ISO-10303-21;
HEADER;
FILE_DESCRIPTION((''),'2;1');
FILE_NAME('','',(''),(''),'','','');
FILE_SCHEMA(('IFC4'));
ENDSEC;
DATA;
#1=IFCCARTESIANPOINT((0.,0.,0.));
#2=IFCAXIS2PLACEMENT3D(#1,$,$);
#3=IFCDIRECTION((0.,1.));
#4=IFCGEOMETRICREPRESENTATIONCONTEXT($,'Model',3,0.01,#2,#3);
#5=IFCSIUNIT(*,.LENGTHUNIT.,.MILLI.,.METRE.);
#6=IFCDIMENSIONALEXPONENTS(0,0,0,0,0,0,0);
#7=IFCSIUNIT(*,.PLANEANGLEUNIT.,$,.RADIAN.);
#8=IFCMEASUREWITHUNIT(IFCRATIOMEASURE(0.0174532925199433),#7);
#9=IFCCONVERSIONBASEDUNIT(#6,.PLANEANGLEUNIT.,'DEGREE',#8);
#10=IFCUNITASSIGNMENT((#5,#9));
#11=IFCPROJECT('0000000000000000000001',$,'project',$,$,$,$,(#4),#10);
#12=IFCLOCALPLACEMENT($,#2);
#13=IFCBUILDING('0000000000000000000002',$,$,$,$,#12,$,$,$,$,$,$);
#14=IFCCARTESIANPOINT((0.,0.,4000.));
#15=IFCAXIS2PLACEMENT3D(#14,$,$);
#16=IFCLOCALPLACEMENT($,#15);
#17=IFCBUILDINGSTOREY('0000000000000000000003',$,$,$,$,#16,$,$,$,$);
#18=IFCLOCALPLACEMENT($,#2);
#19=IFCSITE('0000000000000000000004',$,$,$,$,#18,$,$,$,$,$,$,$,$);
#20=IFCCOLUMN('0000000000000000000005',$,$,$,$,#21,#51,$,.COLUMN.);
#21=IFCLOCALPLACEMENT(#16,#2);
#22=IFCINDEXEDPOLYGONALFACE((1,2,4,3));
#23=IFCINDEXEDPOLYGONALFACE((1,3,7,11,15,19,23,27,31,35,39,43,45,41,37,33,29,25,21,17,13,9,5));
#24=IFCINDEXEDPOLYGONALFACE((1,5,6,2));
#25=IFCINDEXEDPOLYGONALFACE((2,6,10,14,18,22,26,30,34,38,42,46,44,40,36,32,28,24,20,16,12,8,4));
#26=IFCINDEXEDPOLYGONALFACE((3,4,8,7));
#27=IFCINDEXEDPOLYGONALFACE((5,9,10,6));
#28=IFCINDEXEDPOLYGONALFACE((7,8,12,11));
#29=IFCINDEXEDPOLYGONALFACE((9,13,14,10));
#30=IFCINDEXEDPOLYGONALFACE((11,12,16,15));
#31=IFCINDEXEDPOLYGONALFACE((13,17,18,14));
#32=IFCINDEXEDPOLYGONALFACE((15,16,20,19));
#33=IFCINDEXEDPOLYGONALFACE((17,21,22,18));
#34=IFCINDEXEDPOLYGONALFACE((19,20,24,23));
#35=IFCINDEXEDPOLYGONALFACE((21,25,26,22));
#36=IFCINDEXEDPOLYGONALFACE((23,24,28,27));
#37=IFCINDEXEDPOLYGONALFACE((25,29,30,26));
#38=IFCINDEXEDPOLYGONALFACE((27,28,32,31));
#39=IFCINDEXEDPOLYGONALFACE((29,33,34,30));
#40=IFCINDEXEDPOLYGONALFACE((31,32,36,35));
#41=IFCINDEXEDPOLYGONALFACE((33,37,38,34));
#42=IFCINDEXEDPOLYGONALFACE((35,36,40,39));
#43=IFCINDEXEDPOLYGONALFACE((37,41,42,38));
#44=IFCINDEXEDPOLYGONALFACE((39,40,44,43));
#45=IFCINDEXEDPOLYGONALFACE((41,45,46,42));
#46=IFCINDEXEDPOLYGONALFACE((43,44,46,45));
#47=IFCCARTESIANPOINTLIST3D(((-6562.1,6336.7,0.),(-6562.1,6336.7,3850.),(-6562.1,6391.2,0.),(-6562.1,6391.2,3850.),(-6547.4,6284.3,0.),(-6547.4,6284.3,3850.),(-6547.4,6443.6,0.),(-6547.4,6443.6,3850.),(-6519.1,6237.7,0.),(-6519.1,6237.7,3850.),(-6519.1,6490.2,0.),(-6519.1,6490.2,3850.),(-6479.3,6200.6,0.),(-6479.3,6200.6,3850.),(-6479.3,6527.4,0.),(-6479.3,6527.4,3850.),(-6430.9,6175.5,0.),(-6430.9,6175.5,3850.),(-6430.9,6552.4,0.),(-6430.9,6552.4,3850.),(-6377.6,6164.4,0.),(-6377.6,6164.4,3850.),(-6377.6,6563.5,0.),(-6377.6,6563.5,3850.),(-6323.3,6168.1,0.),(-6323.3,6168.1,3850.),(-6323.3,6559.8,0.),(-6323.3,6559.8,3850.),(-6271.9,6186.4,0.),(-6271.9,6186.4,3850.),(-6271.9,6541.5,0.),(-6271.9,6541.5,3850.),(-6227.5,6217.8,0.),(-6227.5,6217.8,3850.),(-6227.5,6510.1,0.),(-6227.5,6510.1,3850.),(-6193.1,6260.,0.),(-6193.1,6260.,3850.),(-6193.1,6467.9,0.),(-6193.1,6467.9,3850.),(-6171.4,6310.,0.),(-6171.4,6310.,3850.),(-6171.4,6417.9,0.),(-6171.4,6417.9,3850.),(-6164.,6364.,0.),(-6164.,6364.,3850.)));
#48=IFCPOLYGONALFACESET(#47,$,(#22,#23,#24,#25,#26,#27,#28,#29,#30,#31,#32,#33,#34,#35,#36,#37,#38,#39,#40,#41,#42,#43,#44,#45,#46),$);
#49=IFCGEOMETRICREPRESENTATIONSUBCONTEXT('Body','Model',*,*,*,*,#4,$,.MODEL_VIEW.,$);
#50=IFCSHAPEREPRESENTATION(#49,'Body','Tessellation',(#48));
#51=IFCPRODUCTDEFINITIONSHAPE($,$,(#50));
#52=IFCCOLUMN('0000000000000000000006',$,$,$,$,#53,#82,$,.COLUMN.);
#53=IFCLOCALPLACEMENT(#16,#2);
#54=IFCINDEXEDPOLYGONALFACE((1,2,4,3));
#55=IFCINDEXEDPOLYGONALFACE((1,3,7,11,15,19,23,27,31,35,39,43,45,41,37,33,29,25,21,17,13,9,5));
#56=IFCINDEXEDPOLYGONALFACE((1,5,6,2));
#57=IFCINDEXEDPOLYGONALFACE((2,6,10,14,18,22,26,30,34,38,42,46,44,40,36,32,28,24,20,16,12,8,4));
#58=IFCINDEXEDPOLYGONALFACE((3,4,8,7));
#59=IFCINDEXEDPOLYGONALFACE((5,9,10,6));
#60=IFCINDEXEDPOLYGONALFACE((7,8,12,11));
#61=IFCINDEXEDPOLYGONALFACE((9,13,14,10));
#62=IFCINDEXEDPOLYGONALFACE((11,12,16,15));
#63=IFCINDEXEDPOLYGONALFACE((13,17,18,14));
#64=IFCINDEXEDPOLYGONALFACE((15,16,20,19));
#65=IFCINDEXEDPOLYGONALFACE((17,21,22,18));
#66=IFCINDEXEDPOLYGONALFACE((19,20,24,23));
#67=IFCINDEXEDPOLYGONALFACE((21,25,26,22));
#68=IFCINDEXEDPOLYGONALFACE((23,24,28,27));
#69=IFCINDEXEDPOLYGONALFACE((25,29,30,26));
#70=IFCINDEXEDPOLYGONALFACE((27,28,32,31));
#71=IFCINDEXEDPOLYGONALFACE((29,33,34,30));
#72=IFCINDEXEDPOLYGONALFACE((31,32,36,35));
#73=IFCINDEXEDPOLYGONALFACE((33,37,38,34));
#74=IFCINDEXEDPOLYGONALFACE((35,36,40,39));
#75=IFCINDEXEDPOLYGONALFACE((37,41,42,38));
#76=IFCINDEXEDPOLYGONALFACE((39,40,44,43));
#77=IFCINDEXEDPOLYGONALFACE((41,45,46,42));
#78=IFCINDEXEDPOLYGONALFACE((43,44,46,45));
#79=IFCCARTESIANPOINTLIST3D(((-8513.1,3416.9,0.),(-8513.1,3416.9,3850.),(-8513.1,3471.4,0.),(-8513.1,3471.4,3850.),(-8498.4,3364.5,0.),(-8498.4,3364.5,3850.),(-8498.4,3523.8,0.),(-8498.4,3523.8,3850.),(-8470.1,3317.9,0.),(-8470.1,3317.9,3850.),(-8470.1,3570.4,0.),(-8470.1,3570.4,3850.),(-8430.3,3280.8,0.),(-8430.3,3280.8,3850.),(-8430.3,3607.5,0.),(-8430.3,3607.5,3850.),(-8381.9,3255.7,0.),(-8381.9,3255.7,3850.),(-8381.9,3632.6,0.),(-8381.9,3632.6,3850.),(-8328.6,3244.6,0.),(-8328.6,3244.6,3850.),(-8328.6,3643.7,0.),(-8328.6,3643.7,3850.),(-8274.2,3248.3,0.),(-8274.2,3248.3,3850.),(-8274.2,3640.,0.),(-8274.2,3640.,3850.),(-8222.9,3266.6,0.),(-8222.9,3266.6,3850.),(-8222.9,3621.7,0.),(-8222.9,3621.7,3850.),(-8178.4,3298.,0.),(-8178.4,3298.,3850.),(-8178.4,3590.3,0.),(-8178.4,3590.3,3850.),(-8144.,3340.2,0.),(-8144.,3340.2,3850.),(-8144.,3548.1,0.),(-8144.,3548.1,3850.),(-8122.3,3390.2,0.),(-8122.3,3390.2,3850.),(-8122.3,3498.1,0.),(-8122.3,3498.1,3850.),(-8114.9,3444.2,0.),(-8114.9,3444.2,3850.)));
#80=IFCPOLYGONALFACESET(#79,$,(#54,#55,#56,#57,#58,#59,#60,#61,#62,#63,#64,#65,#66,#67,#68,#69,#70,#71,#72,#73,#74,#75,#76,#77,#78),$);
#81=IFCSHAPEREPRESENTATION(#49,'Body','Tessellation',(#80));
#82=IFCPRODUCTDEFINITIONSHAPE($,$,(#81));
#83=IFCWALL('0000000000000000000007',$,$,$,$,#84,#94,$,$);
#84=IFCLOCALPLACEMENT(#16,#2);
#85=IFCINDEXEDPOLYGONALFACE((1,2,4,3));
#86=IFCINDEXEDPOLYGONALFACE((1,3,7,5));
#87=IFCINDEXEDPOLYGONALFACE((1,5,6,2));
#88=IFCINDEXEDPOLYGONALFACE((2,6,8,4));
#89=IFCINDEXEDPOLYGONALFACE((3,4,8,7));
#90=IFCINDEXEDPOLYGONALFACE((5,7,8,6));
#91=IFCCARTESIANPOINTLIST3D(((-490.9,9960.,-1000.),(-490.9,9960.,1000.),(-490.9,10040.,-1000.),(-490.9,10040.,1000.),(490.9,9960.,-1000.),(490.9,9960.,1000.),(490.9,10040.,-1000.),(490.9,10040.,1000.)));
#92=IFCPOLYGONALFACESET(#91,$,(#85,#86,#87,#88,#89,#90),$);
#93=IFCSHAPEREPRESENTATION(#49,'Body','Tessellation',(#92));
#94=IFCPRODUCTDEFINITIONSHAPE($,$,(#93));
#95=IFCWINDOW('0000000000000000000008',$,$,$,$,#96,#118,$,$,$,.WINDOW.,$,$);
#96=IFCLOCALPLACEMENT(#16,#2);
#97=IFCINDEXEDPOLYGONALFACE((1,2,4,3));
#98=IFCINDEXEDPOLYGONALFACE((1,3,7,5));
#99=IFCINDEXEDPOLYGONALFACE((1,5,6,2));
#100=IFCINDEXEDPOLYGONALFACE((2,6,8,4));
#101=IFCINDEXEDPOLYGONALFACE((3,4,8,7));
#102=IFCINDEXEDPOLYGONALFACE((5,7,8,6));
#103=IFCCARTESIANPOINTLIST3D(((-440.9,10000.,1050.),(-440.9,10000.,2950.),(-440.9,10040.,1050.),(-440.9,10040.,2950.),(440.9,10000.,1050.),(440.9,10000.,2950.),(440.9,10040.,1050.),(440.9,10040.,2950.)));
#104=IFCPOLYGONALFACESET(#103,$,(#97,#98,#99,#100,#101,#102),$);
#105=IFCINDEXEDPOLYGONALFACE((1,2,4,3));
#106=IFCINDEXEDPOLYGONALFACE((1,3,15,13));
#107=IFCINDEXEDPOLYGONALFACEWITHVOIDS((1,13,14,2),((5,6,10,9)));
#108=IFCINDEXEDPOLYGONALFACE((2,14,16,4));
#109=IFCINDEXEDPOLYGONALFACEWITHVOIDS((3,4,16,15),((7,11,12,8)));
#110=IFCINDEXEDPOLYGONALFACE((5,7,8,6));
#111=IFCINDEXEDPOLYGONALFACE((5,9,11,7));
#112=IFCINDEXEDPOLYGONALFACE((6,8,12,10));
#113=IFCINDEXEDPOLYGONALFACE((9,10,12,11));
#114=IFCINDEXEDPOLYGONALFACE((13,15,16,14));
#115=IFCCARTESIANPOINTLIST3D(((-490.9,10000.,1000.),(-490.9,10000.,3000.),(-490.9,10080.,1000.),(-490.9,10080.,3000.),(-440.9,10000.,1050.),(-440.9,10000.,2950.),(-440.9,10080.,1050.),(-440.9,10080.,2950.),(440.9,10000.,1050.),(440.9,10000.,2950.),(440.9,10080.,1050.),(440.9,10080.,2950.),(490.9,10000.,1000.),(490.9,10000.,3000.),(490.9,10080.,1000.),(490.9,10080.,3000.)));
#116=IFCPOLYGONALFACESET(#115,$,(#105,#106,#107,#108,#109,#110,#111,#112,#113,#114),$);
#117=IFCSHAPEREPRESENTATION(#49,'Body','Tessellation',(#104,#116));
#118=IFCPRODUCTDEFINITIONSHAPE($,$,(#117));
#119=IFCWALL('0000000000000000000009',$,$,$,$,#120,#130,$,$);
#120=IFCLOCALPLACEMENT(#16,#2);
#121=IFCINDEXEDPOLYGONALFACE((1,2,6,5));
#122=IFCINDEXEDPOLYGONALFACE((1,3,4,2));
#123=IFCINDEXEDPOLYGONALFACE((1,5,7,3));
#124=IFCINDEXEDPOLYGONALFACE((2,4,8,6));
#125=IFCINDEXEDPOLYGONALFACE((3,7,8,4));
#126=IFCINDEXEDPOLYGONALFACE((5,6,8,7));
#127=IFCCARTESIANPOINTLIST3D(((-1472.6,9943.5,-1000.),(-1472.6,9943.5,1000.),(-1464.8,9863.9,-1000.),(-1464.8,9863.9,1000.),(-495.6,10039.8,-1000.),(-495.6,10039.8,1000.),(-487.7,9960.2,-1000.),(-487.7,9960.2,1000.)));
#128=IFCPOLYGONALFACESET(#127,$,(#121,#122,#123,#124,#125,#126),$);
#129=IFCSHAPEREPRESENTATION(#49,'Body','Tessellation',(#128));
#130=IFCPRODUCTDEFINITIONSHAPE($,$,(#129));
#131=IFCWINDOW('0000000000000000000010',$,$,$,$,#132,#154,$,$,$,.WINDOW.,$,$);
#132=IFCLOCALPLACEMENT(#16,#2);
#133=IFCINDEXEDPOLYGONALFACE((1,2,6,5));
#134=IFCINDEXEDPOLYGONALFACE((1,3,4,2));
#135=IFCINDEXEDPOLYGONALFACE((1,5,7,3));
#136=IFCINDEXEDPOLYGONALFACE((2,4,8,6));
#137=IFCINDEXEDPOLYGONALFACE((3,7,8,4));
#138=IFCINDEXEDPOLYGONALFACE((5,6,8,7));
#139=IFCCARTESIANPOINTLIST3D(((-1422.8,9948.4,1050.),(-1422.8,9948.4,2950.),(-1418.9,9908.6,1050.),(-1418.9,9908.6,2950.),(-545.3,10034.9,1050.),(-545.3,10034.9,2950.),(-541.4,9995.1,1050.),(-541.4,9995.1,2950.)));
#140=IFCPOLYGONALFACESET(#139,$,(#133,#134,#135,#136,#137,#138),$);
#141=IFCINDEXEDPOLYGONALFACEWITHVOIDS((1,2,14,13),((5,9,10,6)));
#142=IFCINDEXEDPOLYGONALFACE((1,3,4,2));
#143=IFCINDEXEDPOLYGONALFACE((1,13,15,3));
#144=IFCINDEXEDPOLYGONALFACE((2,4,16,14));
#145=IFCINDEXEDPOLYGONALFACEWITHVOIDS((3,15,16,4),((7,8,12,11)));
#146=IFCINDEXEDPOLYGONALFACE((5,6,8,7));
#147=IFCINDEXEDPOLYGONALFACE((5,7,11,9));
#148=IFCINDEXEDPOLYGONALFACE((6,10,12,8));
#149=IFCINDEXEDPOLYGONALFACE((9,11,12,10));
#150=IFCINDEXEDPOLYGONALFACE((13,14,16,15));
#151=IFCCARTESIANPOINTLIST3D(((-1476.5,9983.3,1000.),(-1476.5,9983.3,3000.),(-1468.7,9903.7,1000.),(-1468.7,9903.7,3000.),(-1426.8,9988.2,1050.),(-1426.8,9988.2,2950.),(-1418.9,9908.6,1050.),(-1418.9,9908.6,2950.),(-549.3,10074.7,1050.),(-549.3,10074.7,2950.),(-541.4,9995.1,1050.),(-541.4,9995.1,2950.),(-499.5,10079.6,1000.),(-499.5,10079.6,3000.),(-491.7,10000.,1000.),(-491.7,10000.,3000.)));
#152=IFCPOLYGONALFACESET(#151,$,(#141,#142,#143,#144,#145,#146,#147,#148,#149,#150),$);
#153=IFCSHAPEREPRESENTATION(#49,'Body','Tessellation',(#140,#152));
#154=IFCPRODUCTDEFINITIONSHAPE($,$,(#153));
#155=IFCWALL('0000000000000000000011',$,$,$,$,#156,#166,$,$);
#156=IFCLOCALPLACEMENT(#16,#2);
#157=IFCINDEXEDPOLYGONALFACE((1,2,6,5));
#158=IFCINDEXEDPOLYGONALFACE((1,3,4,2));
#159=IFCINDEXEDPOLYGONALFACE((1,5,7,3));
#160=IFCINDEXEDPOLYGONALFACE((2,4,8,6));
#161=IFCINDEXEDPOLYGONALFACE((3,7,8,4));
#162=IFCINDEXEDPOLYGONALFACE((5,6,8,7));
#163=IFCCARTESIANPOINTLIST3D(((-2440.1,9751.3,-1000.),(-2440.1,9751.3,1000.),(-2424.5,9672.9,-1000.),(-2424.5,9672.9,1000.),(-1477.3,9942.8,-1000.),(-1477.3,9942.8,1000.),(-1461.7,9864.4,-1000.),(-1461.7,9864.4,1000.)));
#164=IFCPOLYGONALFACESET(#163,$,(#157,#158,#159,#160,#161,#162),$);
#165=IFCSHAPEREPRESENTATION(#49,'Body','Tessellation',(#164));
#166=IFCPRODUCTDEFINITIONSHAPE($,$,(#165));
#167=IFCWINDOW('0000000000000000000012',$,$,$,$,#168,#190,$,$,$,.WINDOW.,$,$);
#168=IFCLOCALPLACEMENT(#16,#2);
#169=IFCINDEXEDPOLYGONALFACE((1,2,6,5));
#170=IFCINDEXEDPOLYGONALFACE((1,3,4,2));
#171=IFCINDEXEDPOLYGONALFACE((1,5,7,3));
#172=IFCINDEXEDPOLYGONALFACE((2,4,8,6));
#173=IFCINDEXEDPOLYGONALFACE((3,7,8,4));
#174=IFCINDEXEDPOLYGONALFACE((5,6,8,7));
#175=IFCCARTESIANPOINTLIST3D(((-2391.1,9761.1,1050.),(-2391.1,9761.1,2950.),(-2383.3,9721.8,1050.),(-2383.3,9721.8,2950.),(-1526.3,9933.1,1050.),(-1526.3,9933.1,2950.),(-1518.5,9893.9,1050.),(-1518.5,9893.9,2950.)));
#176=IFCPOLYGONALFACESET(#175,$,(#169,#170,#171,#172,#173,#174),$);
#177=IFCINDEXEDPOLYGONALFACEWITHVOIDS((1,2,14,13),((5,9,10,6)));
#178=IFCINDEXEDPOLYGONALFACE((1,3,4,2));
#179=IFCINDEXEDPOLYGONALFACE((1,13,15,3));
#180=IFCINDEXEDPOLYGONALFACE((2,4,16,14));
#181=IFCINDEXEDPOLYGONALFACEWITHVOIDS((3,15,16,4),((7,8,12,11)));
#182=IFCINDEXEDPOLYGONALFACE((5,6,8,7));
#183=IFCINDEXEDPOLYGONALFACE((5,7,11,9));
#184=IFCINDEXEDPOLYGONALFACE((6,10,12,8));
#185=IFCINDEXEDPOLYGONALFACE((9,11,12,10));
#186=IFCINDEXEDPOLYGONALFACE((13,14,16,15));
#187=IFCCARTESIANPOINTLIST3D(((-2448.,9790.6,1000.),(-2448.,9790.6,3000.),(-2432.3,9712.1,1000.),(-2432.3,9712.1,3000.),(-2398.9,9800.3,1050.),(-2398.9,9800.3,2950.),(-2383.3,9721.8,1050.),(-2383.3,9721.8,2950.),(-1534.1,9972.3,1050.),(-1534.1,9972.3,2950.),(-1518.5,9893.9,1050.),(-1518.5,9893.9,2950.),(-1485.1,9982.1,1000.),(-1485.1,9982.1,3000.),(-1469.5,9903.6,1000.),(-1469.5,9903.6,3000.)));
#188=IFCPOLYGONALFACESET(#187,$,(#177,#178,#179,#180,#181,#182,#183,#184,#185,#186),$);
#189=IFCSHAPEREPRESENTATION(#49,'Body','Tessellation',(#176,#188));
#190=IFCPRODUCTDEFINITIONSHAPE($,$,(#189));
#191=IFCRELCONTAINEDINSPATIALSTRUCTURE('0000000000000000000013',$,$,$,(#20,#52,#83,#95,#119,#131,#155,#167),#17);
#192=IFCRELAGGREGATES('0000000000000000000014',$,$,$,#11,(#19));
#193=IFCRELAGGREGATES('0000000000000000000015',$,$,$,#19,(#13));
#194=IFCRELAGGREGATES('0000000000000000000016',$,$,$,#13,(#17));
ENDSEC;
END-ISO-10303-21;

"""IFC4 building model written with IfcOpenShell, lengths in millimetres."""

from ifc_helpers import new_model, entity, si_unit, converted_unit, direction, frame, origin, origin_2d, place, context, subcontext, project, spatial, rectangle, circle, extrude, element, save


model = new_model("IFC4")

# Units and contexts
model_context = context("Model", 3, precision=0.01, world=origin(), true_north=direction((0.0, 1.0)))
body_context = subcontext(model_context, "Body", "Model", "MODEL_VIEW")
ifc_project = project(units=[si_unit("LENGTHUNIT", "METRE", prefix="MILLI"), converted_unit("PLANEANGLEUNIT", "DEGREE", entity("IfcRatioMeasure", 0.0174532925199433), si_unit("PLANEANGLEUNIT", "RADIAN"), dimensions=[0, 0, 0, 0, 0, 0, 0])], contexts=[model_context])

# Site, building, storey
site_placement = place(None, origin())
site = spatial("IfcSite", under=ifc_project, at=site_placement)
building_placement = place(None, origin())
building = spatial("IfcBuilding", under=site, at=building_placement)
storey_placement = place(None, frame((0.0, 0.0, 4000.0)))
storey = spatial("IfcBuildingStorey", under=building, at=storey_placement)

# Columns
for number, where in (
    (1, (-6364.0, 6364.0, 0.0)),
    (2, (-8314.9, 3444.2, 0.0)),
):
    element("IfcColumn", number, at=place(storey_placement, frame(where)), inside=storey, PredefinedType="COLUMN", context=body_context, shape_type="SweptSolid", body=[
        extrude(circle(Radius=200.0, at=origin_2d()), origin(), (0.0, 0.0, 1.0), 3850.0),
    ])

# Wall
wall_1_placement = place(storey_placement, frame((0.0, 10000.0, -1000.0), z_axis=(0.0, 0.0, 1.0), x_axis=(-10000.0, -0.000437, 0.0)))
element("IfcWall", 3, at=wall_1_placement, inside=storey, context=body_context, shape_type="SweptSolid", body=[
    extrude(rectangle(XDim=981.7, YDim=80.0, at=origin_2d()), origin(), (0.0, 0.0, 1.0), 2000.0),
])

# Window
cartesian_point_1 = entity("IfcCartesianPoint", [-440.9, -950.0])
shared_polyline = entity("IfcPolyline", [cartesian_point_1, entity("IfcCartesianPoint", [-440.9, 950.0]), entity("IfcCartesianPoint", [-440.9, 950.0]), entity("IfcCartesianPoint", [440.9, 950.0]), entity("IfcCartesianPoint", [440.9, 950.0]), entity("IfcCartesianPoint", [440.9, -950.0]), entity("IfcCartesianPoint", [440.9, -950.0]), entity("IfcCartesianPoint", [-440.9, -950.0]), cartesian_point_1])
window_1_placement = place(storey_placement, frame((0.0, 10000.0, 2000.0), z_axis=(0.0, 0.0, 1.0), x_axis=(-10000.0, -0.000437, 0.0)))
cartesian_point_2 = entity("IfcCartesianPoint", [-490.9, -1000.0])
element("IfcWindow", 4, at=window_1_placement, inside=storey, PredefinedType="WINDOW", context=body_context, shape_type="SweptSolid", body=[
    entity("IfcExtrudedAreaSolid", entity("IfcArbitraryClosedProfileDef", "AREA", None, shared_polyline), entity("IfcAxis2Placement3D", entity("IfcCartesianPoint", [0.0, 0.0, 0.0]), entity("IfcDirection", [0.0, -1.0, 0.0]), entity("IfcDirection", [1.0, 0.0, 0.0])), entity("IfcDirection", [0.0, 0.0, 1.0]), 40.0),
    entity("IfcExtrudedAreaSolid", entity("IfcArbitraryProfileDefWithVoids", "AREA", None, entity("IfcPolyline", [cartesian_point_2, entity("IfcCartesianPoint", [-490.9, 1000.0]), entity("IfcCartesianPoint", [-490.9, 1000.0]), entity("IfcCartesianPoint", [490.9, 1000.0]), entity("IfcCartesianPoint", [490.9, 1000.0]), entity("IfcCartesianPoint", [490.9, -1000.0]), entity("IfcCartesianPoint", [490.9, -1000.0]), entity("IfcCartesianPoint", [-490.9, -1000.0]), cartesian_point_2]), [shared_polyline]), entity("IfcAxis2Placement3D", entity("IfcCartesianPoint", [0.0, 0.0, 0.0]), entity("IfcDirection", [0.0, -1.0, 0.0]), entity("IfcDirection", [1.0, 0.0, 0.0])), entity("IfcDirection", [0.0, 0.0, 1.0]), 80.0),
])

# Wall
wall_2_placement = place(storey_placement, frame((-980.2, 9951.8, -1000.0), z_axis=(0.0, 0.0, 1.0), x_axis=(-9951.847302, -980.17105, 0.0)))
element("IfcWall", 5, at=wall_2_placement, inside=storey, context=body_context, shape_type="SweptSolid", body=[
    extrude(rectangle(XDim=981.7, YDim=80.0, at=origin_2d()), origin(), (0.0, 0.0, 1.0), 2000.0),
])

# Window
window_2_placement = place(storey_placement, frame((-980.2, 9951.8, 2000.0), z_axis=(0.0, 0.0, 1.0), x_axis=(-9951.847302, -980.17105, 0.0)))
cartesian_point_3 = entity("IfcCartesianPoint", [-490.9, -1000.0])
element("IfcWindow", 6, at=window_2_placement, inside=storey, PredefinedType="WINDOW", context=body_context, shape_type="SweptSolid", body=[
    entity("IfcExtrudedAreaSolid", entity("IfcArbitraryClosedProfileDef", "AREA", None, shared_polyline), entity("IfcAxis2Placement3D", entity("IfcCartesianPoint", [0.0, 0.0, 0.0]), entity("IfcDirection", [0.0, -1.0, 0.0]), entity("IfcDirection", [1.0, 0.0, 0.0])), entity("IfcDirection", [0.0, 0.0, 1.0]), 40.0),
    entity("IfcExtrudedAreaSolid", entity("IfcArbitraryProfileDefWithVoids", "AREA", None, entity("IfcPolyline", [cartesian_point_3, entity("IfcCartesianPoint", [-490.9, 1000.0]), entity("IfcCartesianPoint", [-490.9, 1000.0]), entity("IfcCartesianPoint", [490.9, 1000.0]), entity("IfcCartesianPoint", [490.9, 1000.0]), entity("IfcCartesianPoint", [490.9, -1000.0]), entity("IfcCartesianPoint", [490.9, -1000.0]), entity("IfcCartesianPoint", [-490.9, -1000.0]), cartesian_point_3]), [shared_polyline]), entity("IfcAxis2Placement3D", entity("IfcCartesianPoint", [0.0, 0.0, 0.0]), entity("IfcDirection", [0.0, -1.0, 0.0]), entity("IfcDirection", [1.0, 0.0, 0.0])), entity("IfcDirection", [0.0, 0.0, 1.0]), 80.0),
])

# Wall
wall_3_placement = place(storey_placement, frame((-1950.9, 9807.9, -1000.0), z_axis=(0.0, 0.0, 1.0), x_axis=(-9807.852795, -1950.903264, 0.0)))
element("IfcWall", 7, at=wall_3_placement, inside=storey, context=body_context, shape_type="SweptSolid", body=[
    extrude(rectangle(XDim=981.7, YDim=80.0, at=origin_2d()), origin(), (0.0, 0.0, 1.0), 2000.0),
])

# Window
window_3_placement = place(storey_placement, frame((-1950.9, 9807.9, 2000.0), z_axis=(0.0, 0.0, 1.0), x_axis=(-9807.852795, -1950.903264, 0.0)))
cartesian_point_4 = entity("IfcCartesianPoint", [-490.9, -1000.0])
element("IfcWindow", 8, at=window_3_placement, inside=storey, PredefinedType="WINDOW", context=body_context, shape_type="SweptSolid", body=[
    entity("IfcExtrudedAreaSolid", entity("IfcArbitraryClosedProfileDef", "AREA", None, shared_polyline), entity("IfcAxis2Placement3D", entity("IfcCartesianPoint", [0.0, 0.0, 0.0]), entity("IfcDirection", [0.0, -1.0, 0.0]), entity("IfcDirection", [1.0, 0.0, 0.0])), entity("IfcDirection", [0.0, 0.0, 1.0]), 40.0),
    entity("IfcExtrudedAreaSolid", entity("IfcArbitraryProfileDefWithVoids", "AREA", None, entity("IfcPolyline", [cartesian_point_4, entity("IfcCartesianPoint", [-490.9, 1000.0]), entity("IfcCartesianPoint", [-490.9, 1000.0]), entity("IfcCartesianPoint", [490.9, 1000.0]), entity("IfcCartesianPoint", [490.9, 1000.0]), entity("IfcCartesianPoint", [490.9, -1000.0]), entity("IfcCartesianPoint", [490.9, -1000.0]), entity("IfcCartesianPoint", [-490.9, -1000.0]), cartesian_point_4]), [shared_polyline]), entity("IfcAxis2Placement3D", entity("IfcCartesianPoint", [0.0, 0.0, 0.0]), entity("IfcDirection", [0.0, -1.0, 0.0]), entity("IfcDirection", [1.0, 0.0, 0.0])), entity("IfcDirection", [0.0, 0.0, 1.0]), 80.0),
])

save(model, "model.ifc")
